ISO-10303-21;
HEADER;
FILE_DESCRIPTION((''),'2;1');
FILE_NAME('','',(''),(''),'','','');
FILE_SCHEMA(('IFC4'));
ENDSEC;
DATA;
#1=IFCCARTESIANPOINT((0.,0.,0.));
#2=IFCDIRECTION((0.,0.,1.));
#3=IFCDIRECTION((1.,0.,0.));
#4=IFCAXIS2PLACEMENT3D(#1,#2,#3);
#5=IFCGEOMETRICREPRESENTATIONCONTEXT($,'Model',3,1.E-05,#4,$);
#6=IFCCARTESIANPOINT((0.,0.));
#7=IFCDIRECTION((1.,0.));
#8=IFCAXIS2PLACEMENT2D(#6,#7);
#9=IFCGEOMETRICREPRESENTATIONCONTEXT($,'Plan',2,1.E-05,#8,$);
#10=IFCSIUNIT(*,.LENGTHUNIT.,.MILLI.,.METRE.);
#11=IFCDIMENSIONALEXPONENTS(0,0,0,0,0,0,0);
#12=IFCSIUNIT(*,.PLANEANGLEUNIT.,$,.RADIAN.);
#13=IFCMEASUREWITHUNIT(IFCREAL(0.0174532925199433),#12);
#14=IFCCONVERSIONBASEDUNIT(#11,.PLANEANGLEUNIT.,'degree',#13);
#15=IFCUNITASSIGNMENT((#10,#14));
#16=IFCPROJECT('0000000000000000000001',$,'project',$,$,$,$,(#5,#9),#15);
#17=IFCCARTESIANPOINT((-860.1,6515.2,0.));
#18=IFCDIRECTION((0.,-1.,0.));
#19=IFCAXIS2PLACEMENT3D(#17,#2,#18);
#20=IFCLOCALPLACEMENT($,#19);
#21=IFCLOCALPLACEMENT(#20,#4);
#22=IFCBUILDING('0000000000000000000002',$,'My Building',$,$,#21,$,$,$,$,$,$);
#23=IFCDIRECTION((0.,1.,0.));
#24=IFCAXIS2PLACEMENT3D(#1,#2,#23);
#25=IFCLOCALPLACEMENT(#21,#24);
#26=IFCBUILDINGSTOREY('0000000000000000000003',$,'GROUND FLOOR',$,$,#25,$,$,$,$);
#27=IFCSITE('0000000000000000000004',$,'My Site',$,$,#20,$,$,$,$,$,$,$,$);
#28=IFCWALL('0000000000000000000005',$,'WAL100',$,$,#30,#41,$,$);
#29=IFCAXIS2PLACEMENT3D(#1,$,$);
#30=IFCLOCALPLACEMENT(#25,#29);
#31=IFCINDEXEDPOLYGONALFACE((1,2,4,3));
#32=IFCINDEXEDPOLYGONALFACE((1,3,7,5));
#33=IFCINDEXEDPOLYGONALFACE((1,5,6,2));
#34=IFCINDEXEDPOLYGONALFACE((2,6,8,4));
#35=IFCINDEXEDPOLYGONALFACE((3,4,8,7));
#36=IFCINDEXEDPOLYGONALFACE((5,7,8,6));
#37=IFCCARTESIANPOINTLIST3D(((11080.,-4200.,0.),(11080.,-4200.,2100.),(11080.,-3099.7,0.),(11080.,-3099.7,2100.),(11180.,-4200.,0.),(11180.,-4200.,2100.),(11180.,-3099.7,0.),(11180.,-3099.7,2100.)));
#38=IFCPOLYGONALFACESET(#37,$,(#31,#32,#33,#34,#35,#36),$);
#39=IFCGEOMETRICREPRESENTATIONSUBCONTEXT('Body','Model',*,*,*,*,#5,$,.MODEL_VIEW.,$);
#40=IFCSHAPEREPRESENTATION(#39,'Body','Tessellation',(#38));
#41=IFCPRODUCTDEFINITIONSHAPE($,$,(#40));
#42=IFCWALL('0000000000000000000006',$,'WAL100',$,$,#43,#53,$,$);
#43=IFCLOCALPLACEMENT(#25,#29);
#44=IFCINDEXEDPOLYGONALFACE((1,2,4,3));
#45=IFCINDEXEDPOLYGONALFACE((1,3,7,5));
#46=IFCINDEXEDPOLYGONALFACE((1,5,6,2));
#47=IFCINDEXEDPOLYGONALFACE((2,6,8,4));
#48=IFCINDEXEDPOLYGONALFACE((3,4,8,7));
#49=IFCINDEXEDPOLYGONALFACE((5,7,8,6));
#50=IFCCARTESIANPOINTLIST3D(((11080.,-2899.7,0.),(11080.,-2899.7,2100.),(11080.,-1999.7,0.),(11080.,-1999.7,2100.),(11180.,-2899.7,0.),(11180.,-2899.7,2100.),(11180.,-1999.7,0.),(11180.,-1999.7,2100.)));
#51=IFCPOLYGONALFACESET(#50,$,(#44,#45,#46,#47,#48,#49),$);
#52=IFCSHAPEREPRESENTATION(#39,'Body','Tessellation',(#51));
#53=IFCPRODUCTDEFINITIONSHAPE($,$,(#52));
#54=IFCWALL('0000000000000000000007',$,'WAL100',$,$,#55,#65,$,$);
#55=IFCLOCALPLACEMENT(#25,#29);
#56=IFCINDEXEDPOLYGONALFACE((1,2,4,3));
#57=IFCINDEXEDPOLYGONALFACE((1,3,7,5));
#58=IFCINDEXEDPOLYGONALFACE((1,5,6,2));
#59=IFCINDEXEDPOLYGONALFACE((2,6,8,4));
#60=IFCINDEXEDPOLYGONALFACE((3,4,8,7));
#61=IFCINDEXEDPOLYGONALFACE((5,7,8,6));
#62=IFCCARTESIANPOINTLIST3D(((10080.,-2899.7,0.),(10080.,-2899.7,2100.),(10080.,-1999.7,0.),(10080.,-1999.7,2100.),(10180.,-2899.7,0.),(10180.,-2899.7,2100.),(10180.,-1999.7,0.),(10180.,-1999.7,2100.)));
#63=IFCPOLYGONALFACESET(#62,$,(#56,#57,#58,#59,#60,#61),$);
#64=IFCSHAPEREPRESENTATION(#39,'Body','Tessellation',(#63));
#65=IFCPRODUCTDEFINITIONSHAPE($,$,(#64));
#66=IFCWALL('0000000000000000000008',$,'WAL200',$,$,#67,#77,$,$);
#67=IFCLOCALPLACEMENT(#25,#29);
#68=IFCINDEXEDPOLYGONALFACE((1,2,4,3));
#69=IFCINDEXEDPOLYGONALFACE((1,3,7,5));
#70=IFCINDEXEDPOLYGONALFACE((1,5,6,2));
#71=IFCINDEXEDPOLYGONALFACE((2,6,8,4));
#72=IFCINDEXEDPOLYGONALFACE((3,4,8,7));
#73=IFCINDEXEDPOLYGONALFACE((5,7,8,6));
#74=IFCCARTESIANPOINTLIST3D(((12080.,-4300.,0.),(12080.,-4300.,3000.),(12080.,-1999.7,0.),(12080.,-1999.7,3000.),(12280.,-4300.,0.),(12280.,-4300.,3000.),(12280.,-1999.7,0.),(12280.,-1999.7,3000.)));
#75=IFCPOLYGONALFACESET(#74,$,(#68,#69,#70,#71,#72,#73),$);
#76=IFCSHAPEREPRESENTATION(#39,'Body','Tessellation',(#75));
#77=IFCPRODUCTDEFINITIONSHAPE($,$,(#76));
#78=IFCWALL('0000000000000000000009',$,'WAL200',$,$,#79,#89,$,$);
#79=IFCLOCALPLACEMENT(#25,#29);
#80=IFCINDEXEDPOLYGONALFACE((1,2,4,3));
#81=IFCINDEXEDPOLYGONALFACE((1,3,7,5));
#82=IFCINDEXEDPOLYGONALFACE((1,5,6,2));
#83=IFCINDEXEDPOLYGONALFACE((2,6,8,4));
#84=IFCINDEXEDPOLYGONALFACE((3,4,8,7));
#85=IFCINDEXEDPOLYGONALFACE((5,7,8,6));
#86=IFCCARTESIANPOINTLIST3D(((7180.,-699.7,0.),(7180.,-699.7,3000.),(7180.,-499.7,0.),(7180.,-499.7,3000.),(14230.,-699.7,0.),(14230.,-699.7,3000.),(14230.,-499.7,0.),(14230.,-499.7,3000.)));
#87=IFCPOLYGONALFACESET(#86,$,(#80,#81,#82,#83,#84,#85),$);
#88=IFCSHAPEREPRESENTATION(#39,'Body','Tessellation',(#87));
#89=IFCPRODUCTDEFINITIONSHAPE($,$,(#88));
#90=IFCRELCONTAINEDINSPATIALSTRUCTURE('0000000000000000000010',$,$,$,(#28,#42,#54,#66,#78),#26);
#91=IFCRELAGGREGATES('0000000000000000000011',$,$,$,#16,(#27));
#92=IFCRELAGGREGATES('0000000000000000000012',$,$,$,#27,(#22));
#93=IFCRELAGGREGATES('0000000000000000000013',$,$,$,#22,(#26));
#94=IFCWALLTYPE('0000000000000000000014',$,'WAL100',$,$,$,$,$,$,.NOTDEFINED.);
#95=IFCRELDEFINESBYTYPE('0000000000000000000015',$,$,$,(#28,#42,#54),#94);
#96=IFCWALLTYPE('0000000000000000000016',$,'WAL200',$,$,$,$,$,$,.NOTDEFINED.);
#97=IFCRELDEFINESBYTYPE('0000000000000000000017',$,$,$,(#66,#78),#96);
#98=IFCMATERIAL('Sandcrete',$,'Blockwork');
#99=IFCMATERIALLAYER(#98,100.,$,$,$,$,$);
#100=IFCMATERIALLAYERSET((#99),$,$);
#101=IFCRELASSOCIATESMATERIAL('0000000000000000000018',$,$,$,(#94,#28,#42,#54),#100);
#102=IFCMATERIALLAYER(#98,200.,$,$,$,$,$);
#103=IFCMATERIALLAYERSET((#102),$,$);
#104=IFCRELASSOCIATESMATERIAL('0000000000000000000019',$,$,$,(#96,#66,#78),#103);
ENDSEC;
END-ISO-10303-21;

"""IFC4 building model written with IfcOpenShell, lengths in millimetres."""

from ifc_helpers import new_model, entity, si_unit, converted_unit, frame, origin_with_axes, origin_2d_with_axis, place, context, subcontext, project, spatial, indexed_curve, outline, extrude, material, layer, layer_set, layer_usage, type_object, element, save


model = new_model("IFC4")

# Units and contexts
model_context = context("Model", 3, precision=1e-05, world=origin_with_axes())
plan_context = context("Plan", 2, precision=1e-05, world=origin_2d_with_axis())
body_context_1 = subcontext(model_context, "Body", "Model", "MODEL_VIEW")
ifc_project = project(units=[si_unit("LENGTHUNIT", "METRE", prefix="MILLI"), converted_unit("PLANEANGLEUNIT", "degree", entity("IfcReal", 0.0174532925199433), si_unit("PLANEANGLEUNIT", "RADIAN"), dimensions=[0, 0, 0, 0, 0, 0, 0])], contexts=[model_context, plan_context])

# Site, building, storey
site_placement = place(None, frame((-860.1, 6515.2, 0.0), z_axis=(0.0, 0.0, 1.0), x_axis=(0.0, -1.0, 0.0)))
site = spatial("IfcSite", under=ifc_project, at=site_placement, Name="My Site")
building_placement = place(site_placement, frame((0.0, 0.0, 0.0), z_axis=(0.0, 0.0, 1.0), x_axis=(1.0, 0.0, 0.0)))
building = spatial("IfcBuilding", under=site, at=building_placement, Name="My Building")
storey_placement = place(building_placement, frame((0.0, 0.0, 0.0), z_axis=(0.0, 0.0, 1.0), x_axis=(0.0, 1.0, 0.0)))
storey = spatial("IfcBuildingStorey", under=building, at=storey_placement, Name="GROUND FLOOR")

# Shared definitions
ifc_material = material(Name="Sandcrete", Category="Blockwork")
ifc_layer_1 = layer(ifc_material, 100.0)
ifc_layer_set_1 = layer_set([ifc_layer_1])
wall_type_1 = type_object("IfcWallType", Name="WAL100", PredefinedType="NOTDEFINED", material=ifc_layer_set_1)

# Walls
ifc_layer_usage_1 = layer_usage(ifc_layer_set_1, "AXIS2", "POSITIVE", 0.0)
wall_1_placement = place(storey_placement, frame((11080.0, -3099.7, 0.0), z_axis=(0.0, 0.0, 1.0), x_axis=(0.0, -1.0, 0.0)))
element("IfcWall", 1, at=wall_1_placement, inside=storey, type_object=wall_type_1, material=ifc_layer_usage_1, Name="WAL100", context=body_context_1, shape_type="SweptSolid", body=[
    extrude(outline(indexed_curve([(0.0, 0.0), (0.0, 100.0), (1100.3, 100.0), (1100.3, 0.0), (0.0, 0.0)], self_intersect=False)), origin_with_axes(), (0.0, 0.0, 1.0), 2100.0),
])
ifc_layer_usage_2 = layer_usage(ifc_layer_set_1, "AXIS2", "POSITIVE", 0.0)
wall_2_placement = place(storey_placement, frame((11080.0, -1999.7, 0.0), z_axis=(0.0, 0.0, 1.0), x_axis=(0.0, -1.0, 0.0)))
element("IfcWall", 2, at=wall_2_placement, inside=storey, type_object=wall_type_1, material=ifc_layer_usage_2, Name="WAL100", context=body_context_1, shape_type="SweptSolid", body=[
    extrude(outline(indexed_curve([(0.0, 0.0), (0.0, 100.0), (900.0, 100.0), (900.0, 0.0), (0.0, 0.0)], self_intersect=False)), origin_with_axes(), (0.0, 0.0, 1.0), 2100.0),
])
ifc_layer_usage_3 = layer_usage(ifc_layer_set_1, "AXIS2", "POSITIVE", 0.0)
wall_3_placement = place(storey_placement, frame((10080.0, -1999.7, 0.0), z_axis=(0.0, 0.0, 1.0), x_axis=(-0.000001, -1.0, 0.0)))
element("IfcWall", 3, at=wall_3_placement, inside=storey, type_object=wall_type_1, material=ifc_layer_usage_3, Name="WAL100", context=body_context_1, shape_type="SweptSolid", body=[
    extrude(outline(indexed_curve([(0.0, 0.0), (0.0, 100.0), (900.0, 100.0), (900.0, 0.0), (0.0, 0.0)], self_intersect=False)), origin_with_axes(), (0.0, 0.0, 1.0), 2100.0),
])
ifc_layer_2 = layer(ifc_material, 200.0)
ifc_layer_set_2 = layer_set([ifc_layer_2])
ifc_layer_usage_4 = layer_usage(ifc_layer_set_2, "AXIS2", "POSITIVE", 0.0)
wall_type_2 = type_object("IfcWallType", Name="WAL200", PredefinedType="NOTDEFINED", material=ifc_layer_set_2)
wall_4_placement = place(storey_placement, frame((12080.0, -1999.7, 0.0), z_axis=(0.0, 0.0, 1.0), x_axis=(0.0, -1.0, 0.0)))
element("IfcWall", 4, at=wall_4_placement, inside=storey, type_object=wall_type_2, material=ifc_layer_usage_4, Name="WAL200", context=body_context_1, shape_type="SweptSolid", body=[
    extrude(outline(indexed_curve([(0.0, 0.0), (0.0, 200.0), (2300.3, 200.0), (2300.3, 0.0), (0.0, 0.0)], self_intersect=False)), origin_with_axes(), (0.0, 0.0, 1.0), 3000.0),
])
ifc_layer_usage_5 = layer_usage(ifc_layer_set_2, "AXIS2", "POSITIVE", 0.0)
wall_5_placement = place(storey_placement, frame((14230.0, -499.7, 0.0), z_axis=(0.0, 0.0, 1.0), x_axis=(-1.0, 0.0, 0.0)))
element("IfcWall", 5, at=wall_5_placement, inside=storey, type_object=wall_type_2, material=ifc_layer_usage_5, Name="WAL200", context=body_context_1, shape_type="SweptSolid", body=[
    extrude(outline(indexed_curve([(0.0, 0.0), (0.0, 200.0), (7050.0, 200.0), (7050.0, 0.0), (0.0, 0.0)], self_intersect=False)), origin_with_axes(), (0.0, 0.0, 1.0), 3000.0),
])

save(model, "model.ifc")
